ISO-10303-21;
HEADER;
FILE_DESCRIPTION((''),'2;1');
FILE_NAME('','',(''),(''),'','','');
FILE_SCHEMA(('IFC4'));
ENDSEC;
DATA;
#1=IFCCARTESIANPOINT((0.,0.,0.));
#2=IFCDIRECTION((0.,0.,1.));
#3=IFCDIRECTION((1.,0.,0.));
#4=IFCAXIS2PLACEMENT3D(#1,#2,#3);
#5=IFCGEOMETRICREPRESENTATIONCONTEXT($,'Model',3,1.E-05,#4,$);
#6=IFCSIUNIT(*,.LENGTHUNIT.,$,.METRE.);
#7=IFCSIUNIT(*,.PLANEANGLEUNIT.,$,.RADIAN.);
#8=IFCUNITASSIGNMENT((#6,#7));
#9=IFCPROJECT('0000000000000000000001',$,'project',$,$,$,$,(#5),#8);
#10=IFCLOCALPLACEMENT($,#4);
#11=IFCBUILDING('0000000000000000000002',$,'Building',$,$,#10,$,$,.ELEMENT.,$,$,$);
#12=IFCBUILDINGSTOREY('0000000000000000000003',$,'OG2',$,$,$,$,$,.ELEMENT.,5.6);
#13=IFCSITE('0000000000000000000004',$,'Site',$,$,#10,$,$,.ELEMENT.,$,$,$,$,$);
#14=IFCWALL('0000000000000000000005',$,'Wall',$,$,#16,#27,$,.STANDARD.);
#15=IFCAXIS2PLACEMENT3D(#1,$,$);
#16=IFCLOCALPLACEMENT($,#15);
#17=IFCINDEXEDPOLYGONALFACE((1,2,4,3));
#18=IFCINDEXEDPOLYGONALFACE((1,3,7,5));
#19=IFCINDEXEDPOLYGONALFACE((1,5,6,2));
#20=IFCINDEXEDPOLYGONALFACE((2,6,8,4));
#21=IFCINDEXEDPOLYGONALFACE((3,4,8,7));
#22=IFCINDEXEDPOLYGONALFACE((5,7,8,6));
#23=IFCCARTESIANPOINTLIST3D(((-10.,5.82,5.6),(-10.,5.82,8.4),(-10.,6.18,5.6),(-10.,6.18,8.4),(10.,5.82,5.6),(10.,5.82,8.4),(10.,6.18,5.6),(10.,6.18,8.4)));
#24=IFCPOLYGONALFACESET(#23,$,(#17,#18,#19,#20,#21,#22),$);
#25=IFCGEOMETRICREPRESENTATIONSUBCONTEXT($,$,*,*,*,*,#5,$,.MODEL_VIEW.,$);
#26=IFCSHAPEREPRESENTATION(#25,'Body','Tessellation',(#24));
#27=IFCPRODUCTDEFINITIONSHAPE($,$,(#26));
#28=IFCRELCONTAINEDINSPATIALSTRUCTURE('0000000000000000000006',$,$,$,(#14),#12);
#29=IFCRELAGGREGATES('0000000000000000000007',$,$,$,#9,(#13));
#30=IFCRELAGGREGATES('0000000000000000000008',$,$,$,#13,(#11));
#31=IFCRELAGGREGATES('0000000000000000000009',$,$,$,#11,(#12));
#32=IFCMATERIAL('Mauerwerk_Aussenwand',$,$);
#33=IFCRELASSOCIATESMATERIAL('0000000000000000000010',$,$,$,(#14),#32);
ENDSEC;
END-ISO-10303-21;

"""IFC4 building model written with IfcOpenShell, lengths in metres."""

from ifc_helpers import new_model, si_unit, frame, frame_2d, origin, origin_with_axes, place, context, subcontext, project, spatial, rectangle, extrude, material, element, save


model = new_model("IFC4")

# Units and contexts
model_context = context("Model", 3, precision=1e-05, world=origin_with_axes())
sub_context = subcontext(model_context, None, None, "MODEL_VIEW")
ifc_project = project(units=[si_unit("LENGTHUNIT", "METRE"), si_unit("PLANEANGLEUNIT", "RADIAN")], contexts=[model_context])

# Site, building, storey
placement_1 = place(None, origin_with_axes())
site = spatial("IfcSite", under=ifc_project, at=placement_1, Name="Site", CompositionType="ELEMENT")
building = spatial("IfcBuilding", under=site, at=placement_1, Name="Building", CompositionType="ELEMENT")
storey = spatial("IfcBuildingStorey", under=building, Name="OG2", CompositionType="ELEMENT", Elevation=5.6)

# Wall
ifc_material = material(Name="Mauerwerk_Aussenwand")
placement_2 = place(None, origin_with_axes())
placement_3 = place(placement_2, frame((0.0, 0.0, 5.6)))
wall_placement = place(placement_3, frame((-10.0, 6.0, 0.0), x_axis=(1.0, 0.0, 0.0)))
element("IfcWall", 1, at=wall_placement, inside=storey, material=ifc_material, Name="Wall", PredefinedType="STANDARD", context=sub_context, shape_type="SweptSolid", body=[
    extrude(rectangle(XDim=20.0, YDim=0.36, at=frame_2d((10.0, 0.0))), origin(), (0.0, 0.0, 1.0), 2.8),
])

save(model, "model.ifc")
